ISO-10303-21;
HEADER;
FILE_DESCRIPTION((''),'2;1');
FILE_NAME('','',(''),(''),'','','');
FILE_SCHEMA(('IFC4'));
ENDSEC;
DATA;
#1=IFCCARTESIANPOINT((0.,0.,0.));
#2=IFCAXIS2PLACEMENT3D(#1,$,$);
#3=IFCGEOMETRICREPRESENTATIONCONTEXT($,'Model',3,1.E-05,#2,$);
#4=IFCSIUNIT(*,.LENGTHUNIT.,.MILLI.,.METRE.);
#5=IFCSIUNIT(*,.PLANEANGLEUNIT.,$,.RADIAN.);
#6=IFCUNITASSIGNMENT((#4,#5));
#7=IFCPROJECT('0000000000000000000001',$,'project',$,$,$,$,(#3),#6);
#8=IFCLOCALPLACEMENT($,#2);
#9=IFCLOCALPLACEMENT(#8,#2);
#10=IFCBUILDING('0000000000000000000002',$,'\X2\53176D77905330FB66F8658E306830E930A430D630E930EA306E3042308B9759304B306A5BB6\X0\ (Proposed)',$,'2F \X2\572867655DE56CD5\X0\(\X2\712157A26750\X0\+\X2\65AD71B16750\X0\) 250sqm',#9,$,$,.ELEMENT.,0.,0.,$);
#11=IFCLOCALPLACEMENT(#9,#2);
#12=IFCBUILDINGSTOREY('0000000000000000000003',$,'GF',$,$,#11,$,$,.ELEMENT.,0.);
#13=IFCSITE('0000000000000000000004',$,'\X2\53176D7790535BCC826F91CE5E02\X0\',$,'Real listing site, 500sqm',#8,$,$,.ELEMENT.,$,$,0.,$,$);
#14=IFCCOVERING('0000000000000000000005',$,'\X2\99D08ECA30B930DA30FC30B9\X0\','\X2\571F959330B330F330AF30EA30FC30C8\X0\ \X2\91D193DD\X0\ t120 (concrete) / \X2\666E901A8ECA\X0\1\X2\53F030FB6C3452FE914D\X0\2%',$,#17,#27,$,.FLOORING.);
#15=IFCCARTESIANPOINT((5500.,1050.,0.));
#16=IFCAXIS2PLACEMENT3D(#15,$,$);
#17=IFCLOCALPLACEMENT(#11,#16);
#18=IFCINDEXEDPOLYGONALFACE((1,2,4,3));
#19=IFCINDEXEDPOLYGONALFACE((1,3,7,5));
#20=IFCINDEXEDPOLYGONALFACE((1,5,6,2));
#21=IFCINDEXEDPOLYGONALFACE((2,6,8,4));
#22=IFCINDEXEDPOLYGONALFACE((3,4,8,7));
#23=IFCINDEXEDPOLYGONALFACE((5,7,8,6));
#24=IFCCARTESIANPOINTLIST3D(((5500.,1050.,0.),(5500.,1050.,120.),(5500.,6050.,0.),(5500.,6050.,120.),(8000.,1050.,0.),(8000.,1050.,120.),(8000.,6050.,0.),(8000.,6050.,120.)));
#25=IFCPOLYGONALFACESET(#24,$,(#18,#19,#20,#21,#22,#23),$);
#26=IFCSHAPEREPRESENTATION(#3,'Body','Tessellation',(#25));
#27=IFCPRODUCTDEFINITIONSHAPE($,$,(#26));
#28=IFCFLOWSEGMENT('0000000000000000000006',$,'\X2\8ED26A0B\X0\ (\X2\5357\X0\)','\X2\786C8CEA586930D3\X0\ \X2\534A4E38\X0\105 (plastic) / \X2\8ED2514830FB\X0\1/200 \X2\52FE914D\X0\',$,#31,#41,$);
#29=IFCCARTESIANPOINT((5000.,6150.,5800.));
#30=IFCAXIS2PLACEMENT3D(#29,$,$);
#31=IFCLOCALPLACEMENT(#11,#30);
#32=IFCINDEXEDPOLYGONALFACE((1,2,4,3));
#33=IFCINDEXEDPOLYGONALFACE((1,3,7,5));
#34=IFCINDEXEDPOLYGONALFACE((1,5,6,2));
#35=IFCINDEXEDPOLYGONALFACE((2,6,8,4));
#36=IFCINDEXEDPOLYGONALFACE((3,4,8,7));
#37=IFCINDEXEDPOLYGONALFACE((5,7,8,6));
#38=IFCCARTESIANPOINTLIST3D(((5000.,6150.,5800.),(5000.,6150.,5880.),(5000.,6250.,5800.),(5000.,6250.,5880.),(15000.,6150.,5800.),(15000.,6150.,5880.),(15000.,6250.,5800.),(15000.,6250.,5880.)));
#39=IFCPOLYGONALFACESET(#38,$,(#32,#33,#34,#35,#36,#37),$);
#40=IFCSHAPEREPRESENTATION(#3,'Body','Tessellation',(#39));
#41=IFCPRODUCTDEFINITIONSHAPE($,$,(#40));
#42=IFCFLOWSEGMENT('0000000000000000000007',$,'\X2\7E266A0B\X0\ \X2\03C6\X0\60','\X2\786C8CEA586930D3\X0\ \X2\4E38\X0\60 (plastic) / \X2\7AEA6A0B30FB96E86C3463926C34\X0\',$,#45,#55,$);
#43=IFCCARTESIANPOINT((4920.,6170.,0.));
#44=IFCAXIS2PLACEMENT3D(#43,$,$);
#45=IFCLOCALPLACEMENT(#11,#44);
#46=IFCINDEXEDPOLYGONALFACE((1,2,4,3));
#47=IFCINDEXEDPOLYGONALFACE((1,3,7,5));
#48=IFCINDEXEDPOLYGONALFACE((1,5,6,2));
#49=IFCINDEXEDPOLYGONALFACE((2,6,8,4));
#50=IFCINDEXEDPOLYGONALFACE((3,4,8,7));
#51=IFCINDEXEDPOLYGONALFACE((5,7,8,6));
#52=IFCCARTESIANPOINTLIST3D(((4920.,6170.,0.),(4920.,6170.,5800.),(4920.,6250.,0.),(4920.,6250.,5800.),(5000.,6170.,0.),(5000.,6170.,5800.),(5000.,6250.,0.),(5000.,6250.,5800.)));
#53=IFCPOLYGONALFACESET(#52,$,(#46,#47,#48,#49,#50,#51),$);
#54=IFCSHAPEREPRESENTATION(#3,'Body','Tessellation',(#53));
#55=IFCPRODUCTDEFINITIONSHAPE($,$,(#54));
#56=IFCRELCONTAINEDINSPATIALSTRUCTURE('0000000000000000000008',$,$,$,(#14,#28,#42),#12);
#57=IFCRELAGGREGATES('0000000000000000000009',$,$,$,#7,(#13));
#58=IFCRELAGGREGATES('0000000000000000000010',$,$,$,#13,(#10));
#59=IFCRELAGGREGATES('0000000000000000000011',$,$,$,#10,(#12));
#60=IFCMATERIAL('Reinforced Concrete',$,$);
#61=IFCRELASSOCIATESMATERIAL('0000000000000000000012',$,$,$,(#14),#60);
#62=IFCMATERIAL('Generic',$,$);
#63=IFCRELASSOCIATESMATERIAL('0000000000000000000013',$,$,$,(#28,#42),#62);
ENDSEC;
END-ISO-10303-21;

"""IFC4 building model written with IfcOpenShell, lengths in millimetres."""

from ifc_helpers import new_model, si_unit, frame, frame_2d, origin, place, context, project, spatial, rectangle, extrude, material, element, save


model = new_model("IFC4")

# Units and contexts
model_context = context("Model", 3, precision=1e-05, world=origin())
ifc_project = project(units=[si_unit("LENGTHUNIT", "METRE", prefix="MILLI"), si_unit("PLANEANGLEUNIT", "RADIAN")], contexts=[model_context])

# Site, building, storey
site_placement = place(None, origin())
site = spatial("IfcSite", under=ifc_project, at=site_placement, Name="北海道富良野市", ObjectType="Real listing site, 500sqm", CompositionType="ELEMENT", RefElevation=0.0)
building_placement = place(site_placement, origin())
building = spatial("IfcBuilding", under=site, at=building_placement, Name="北海道・書斎とライブラリのある静かな家 (Proposed)", ObjectType="2F 在来工法(無垢材+断熱材) 250sqm", CompositionType="ELEMENT", ElevationOfRefHeight=0.0, ElevationOfTerrain=0.0)
storey_placement = place(building_placement, origin())
storey = spatial("IfcBuildingStorey", under=building, at=storey_placement, Name="GF", CompositionType="ELEMENT", Elevation=0.0)

# Shared definitions
ifc_material_1 = material(Name="Reinforced Concrete")

# Covering
covering_placement = place(storey_placement, frame((5500.0, 1050.0, 0.0)))
element("IfcCovering", 1, at=covering_placement, inside=storey, material=ifc_material_1, Name="駐車スペース", Description="土間コンクリート 金鏝 t120 (concrete) / 普通車1台・水勾配2%", PredefinedType="FLOORING", context=model_context, shape_type="SweptSolid", body=[
    extrude(rectangle(XDim=2500.0, YDim=5000.0, at=frame_2d((1250.0, 2500.0))), frame((5500.0, 1050.0, 0.0)), (0.0, 0.0, 1.0), 120.0),
])

# Flow segments
ifc_material_2 = material(Name="Generic")
flow_segment_1_placement = place(storey_placement, frame((5000.0, 6150.0, 5800.0)))
element("IfcFlowSegment", 2, at=flow_segment_1_placement, inside=storey, material=ifc_material_2, Name="軒樋 (南)", Description="硬質塩ビ 半丸105 (plastic) / 軒先・1/200 勾配", context=model_context, shape_type="SweptSolid", body=[
    extrude(rectangle(XDim=10000.0, YDim=100.0, at=frame_2d((5000.0, 50.0))), frame((5000.0, 6150.0, 5800.0)), (0.0, 0.0, 1.0), 80.0),
])
flow_segment_2_placement = place(storey_placement, frame((4920.0, 6170.0, 0.0)))
element("IfcFlowSegment", 3, at=flow_segment_2_placement, inside=storey, material=ifc_material_2, Name="縦樋 φ60", Description="硬質塩ビ 丸60 (plastic) / 竪樋・雨水排水", context=model_context, shape_type="SweptSolid", body=[
    extrude(rectangle(XDim=80.0, YDim=80.0, at=frame_2d((40.0, 40.0))), frame((4920.0, 6170.0, 0.0)), (0.0, 0.0, 1.0), 5800.0),
])

save(model, "model.ifc")
